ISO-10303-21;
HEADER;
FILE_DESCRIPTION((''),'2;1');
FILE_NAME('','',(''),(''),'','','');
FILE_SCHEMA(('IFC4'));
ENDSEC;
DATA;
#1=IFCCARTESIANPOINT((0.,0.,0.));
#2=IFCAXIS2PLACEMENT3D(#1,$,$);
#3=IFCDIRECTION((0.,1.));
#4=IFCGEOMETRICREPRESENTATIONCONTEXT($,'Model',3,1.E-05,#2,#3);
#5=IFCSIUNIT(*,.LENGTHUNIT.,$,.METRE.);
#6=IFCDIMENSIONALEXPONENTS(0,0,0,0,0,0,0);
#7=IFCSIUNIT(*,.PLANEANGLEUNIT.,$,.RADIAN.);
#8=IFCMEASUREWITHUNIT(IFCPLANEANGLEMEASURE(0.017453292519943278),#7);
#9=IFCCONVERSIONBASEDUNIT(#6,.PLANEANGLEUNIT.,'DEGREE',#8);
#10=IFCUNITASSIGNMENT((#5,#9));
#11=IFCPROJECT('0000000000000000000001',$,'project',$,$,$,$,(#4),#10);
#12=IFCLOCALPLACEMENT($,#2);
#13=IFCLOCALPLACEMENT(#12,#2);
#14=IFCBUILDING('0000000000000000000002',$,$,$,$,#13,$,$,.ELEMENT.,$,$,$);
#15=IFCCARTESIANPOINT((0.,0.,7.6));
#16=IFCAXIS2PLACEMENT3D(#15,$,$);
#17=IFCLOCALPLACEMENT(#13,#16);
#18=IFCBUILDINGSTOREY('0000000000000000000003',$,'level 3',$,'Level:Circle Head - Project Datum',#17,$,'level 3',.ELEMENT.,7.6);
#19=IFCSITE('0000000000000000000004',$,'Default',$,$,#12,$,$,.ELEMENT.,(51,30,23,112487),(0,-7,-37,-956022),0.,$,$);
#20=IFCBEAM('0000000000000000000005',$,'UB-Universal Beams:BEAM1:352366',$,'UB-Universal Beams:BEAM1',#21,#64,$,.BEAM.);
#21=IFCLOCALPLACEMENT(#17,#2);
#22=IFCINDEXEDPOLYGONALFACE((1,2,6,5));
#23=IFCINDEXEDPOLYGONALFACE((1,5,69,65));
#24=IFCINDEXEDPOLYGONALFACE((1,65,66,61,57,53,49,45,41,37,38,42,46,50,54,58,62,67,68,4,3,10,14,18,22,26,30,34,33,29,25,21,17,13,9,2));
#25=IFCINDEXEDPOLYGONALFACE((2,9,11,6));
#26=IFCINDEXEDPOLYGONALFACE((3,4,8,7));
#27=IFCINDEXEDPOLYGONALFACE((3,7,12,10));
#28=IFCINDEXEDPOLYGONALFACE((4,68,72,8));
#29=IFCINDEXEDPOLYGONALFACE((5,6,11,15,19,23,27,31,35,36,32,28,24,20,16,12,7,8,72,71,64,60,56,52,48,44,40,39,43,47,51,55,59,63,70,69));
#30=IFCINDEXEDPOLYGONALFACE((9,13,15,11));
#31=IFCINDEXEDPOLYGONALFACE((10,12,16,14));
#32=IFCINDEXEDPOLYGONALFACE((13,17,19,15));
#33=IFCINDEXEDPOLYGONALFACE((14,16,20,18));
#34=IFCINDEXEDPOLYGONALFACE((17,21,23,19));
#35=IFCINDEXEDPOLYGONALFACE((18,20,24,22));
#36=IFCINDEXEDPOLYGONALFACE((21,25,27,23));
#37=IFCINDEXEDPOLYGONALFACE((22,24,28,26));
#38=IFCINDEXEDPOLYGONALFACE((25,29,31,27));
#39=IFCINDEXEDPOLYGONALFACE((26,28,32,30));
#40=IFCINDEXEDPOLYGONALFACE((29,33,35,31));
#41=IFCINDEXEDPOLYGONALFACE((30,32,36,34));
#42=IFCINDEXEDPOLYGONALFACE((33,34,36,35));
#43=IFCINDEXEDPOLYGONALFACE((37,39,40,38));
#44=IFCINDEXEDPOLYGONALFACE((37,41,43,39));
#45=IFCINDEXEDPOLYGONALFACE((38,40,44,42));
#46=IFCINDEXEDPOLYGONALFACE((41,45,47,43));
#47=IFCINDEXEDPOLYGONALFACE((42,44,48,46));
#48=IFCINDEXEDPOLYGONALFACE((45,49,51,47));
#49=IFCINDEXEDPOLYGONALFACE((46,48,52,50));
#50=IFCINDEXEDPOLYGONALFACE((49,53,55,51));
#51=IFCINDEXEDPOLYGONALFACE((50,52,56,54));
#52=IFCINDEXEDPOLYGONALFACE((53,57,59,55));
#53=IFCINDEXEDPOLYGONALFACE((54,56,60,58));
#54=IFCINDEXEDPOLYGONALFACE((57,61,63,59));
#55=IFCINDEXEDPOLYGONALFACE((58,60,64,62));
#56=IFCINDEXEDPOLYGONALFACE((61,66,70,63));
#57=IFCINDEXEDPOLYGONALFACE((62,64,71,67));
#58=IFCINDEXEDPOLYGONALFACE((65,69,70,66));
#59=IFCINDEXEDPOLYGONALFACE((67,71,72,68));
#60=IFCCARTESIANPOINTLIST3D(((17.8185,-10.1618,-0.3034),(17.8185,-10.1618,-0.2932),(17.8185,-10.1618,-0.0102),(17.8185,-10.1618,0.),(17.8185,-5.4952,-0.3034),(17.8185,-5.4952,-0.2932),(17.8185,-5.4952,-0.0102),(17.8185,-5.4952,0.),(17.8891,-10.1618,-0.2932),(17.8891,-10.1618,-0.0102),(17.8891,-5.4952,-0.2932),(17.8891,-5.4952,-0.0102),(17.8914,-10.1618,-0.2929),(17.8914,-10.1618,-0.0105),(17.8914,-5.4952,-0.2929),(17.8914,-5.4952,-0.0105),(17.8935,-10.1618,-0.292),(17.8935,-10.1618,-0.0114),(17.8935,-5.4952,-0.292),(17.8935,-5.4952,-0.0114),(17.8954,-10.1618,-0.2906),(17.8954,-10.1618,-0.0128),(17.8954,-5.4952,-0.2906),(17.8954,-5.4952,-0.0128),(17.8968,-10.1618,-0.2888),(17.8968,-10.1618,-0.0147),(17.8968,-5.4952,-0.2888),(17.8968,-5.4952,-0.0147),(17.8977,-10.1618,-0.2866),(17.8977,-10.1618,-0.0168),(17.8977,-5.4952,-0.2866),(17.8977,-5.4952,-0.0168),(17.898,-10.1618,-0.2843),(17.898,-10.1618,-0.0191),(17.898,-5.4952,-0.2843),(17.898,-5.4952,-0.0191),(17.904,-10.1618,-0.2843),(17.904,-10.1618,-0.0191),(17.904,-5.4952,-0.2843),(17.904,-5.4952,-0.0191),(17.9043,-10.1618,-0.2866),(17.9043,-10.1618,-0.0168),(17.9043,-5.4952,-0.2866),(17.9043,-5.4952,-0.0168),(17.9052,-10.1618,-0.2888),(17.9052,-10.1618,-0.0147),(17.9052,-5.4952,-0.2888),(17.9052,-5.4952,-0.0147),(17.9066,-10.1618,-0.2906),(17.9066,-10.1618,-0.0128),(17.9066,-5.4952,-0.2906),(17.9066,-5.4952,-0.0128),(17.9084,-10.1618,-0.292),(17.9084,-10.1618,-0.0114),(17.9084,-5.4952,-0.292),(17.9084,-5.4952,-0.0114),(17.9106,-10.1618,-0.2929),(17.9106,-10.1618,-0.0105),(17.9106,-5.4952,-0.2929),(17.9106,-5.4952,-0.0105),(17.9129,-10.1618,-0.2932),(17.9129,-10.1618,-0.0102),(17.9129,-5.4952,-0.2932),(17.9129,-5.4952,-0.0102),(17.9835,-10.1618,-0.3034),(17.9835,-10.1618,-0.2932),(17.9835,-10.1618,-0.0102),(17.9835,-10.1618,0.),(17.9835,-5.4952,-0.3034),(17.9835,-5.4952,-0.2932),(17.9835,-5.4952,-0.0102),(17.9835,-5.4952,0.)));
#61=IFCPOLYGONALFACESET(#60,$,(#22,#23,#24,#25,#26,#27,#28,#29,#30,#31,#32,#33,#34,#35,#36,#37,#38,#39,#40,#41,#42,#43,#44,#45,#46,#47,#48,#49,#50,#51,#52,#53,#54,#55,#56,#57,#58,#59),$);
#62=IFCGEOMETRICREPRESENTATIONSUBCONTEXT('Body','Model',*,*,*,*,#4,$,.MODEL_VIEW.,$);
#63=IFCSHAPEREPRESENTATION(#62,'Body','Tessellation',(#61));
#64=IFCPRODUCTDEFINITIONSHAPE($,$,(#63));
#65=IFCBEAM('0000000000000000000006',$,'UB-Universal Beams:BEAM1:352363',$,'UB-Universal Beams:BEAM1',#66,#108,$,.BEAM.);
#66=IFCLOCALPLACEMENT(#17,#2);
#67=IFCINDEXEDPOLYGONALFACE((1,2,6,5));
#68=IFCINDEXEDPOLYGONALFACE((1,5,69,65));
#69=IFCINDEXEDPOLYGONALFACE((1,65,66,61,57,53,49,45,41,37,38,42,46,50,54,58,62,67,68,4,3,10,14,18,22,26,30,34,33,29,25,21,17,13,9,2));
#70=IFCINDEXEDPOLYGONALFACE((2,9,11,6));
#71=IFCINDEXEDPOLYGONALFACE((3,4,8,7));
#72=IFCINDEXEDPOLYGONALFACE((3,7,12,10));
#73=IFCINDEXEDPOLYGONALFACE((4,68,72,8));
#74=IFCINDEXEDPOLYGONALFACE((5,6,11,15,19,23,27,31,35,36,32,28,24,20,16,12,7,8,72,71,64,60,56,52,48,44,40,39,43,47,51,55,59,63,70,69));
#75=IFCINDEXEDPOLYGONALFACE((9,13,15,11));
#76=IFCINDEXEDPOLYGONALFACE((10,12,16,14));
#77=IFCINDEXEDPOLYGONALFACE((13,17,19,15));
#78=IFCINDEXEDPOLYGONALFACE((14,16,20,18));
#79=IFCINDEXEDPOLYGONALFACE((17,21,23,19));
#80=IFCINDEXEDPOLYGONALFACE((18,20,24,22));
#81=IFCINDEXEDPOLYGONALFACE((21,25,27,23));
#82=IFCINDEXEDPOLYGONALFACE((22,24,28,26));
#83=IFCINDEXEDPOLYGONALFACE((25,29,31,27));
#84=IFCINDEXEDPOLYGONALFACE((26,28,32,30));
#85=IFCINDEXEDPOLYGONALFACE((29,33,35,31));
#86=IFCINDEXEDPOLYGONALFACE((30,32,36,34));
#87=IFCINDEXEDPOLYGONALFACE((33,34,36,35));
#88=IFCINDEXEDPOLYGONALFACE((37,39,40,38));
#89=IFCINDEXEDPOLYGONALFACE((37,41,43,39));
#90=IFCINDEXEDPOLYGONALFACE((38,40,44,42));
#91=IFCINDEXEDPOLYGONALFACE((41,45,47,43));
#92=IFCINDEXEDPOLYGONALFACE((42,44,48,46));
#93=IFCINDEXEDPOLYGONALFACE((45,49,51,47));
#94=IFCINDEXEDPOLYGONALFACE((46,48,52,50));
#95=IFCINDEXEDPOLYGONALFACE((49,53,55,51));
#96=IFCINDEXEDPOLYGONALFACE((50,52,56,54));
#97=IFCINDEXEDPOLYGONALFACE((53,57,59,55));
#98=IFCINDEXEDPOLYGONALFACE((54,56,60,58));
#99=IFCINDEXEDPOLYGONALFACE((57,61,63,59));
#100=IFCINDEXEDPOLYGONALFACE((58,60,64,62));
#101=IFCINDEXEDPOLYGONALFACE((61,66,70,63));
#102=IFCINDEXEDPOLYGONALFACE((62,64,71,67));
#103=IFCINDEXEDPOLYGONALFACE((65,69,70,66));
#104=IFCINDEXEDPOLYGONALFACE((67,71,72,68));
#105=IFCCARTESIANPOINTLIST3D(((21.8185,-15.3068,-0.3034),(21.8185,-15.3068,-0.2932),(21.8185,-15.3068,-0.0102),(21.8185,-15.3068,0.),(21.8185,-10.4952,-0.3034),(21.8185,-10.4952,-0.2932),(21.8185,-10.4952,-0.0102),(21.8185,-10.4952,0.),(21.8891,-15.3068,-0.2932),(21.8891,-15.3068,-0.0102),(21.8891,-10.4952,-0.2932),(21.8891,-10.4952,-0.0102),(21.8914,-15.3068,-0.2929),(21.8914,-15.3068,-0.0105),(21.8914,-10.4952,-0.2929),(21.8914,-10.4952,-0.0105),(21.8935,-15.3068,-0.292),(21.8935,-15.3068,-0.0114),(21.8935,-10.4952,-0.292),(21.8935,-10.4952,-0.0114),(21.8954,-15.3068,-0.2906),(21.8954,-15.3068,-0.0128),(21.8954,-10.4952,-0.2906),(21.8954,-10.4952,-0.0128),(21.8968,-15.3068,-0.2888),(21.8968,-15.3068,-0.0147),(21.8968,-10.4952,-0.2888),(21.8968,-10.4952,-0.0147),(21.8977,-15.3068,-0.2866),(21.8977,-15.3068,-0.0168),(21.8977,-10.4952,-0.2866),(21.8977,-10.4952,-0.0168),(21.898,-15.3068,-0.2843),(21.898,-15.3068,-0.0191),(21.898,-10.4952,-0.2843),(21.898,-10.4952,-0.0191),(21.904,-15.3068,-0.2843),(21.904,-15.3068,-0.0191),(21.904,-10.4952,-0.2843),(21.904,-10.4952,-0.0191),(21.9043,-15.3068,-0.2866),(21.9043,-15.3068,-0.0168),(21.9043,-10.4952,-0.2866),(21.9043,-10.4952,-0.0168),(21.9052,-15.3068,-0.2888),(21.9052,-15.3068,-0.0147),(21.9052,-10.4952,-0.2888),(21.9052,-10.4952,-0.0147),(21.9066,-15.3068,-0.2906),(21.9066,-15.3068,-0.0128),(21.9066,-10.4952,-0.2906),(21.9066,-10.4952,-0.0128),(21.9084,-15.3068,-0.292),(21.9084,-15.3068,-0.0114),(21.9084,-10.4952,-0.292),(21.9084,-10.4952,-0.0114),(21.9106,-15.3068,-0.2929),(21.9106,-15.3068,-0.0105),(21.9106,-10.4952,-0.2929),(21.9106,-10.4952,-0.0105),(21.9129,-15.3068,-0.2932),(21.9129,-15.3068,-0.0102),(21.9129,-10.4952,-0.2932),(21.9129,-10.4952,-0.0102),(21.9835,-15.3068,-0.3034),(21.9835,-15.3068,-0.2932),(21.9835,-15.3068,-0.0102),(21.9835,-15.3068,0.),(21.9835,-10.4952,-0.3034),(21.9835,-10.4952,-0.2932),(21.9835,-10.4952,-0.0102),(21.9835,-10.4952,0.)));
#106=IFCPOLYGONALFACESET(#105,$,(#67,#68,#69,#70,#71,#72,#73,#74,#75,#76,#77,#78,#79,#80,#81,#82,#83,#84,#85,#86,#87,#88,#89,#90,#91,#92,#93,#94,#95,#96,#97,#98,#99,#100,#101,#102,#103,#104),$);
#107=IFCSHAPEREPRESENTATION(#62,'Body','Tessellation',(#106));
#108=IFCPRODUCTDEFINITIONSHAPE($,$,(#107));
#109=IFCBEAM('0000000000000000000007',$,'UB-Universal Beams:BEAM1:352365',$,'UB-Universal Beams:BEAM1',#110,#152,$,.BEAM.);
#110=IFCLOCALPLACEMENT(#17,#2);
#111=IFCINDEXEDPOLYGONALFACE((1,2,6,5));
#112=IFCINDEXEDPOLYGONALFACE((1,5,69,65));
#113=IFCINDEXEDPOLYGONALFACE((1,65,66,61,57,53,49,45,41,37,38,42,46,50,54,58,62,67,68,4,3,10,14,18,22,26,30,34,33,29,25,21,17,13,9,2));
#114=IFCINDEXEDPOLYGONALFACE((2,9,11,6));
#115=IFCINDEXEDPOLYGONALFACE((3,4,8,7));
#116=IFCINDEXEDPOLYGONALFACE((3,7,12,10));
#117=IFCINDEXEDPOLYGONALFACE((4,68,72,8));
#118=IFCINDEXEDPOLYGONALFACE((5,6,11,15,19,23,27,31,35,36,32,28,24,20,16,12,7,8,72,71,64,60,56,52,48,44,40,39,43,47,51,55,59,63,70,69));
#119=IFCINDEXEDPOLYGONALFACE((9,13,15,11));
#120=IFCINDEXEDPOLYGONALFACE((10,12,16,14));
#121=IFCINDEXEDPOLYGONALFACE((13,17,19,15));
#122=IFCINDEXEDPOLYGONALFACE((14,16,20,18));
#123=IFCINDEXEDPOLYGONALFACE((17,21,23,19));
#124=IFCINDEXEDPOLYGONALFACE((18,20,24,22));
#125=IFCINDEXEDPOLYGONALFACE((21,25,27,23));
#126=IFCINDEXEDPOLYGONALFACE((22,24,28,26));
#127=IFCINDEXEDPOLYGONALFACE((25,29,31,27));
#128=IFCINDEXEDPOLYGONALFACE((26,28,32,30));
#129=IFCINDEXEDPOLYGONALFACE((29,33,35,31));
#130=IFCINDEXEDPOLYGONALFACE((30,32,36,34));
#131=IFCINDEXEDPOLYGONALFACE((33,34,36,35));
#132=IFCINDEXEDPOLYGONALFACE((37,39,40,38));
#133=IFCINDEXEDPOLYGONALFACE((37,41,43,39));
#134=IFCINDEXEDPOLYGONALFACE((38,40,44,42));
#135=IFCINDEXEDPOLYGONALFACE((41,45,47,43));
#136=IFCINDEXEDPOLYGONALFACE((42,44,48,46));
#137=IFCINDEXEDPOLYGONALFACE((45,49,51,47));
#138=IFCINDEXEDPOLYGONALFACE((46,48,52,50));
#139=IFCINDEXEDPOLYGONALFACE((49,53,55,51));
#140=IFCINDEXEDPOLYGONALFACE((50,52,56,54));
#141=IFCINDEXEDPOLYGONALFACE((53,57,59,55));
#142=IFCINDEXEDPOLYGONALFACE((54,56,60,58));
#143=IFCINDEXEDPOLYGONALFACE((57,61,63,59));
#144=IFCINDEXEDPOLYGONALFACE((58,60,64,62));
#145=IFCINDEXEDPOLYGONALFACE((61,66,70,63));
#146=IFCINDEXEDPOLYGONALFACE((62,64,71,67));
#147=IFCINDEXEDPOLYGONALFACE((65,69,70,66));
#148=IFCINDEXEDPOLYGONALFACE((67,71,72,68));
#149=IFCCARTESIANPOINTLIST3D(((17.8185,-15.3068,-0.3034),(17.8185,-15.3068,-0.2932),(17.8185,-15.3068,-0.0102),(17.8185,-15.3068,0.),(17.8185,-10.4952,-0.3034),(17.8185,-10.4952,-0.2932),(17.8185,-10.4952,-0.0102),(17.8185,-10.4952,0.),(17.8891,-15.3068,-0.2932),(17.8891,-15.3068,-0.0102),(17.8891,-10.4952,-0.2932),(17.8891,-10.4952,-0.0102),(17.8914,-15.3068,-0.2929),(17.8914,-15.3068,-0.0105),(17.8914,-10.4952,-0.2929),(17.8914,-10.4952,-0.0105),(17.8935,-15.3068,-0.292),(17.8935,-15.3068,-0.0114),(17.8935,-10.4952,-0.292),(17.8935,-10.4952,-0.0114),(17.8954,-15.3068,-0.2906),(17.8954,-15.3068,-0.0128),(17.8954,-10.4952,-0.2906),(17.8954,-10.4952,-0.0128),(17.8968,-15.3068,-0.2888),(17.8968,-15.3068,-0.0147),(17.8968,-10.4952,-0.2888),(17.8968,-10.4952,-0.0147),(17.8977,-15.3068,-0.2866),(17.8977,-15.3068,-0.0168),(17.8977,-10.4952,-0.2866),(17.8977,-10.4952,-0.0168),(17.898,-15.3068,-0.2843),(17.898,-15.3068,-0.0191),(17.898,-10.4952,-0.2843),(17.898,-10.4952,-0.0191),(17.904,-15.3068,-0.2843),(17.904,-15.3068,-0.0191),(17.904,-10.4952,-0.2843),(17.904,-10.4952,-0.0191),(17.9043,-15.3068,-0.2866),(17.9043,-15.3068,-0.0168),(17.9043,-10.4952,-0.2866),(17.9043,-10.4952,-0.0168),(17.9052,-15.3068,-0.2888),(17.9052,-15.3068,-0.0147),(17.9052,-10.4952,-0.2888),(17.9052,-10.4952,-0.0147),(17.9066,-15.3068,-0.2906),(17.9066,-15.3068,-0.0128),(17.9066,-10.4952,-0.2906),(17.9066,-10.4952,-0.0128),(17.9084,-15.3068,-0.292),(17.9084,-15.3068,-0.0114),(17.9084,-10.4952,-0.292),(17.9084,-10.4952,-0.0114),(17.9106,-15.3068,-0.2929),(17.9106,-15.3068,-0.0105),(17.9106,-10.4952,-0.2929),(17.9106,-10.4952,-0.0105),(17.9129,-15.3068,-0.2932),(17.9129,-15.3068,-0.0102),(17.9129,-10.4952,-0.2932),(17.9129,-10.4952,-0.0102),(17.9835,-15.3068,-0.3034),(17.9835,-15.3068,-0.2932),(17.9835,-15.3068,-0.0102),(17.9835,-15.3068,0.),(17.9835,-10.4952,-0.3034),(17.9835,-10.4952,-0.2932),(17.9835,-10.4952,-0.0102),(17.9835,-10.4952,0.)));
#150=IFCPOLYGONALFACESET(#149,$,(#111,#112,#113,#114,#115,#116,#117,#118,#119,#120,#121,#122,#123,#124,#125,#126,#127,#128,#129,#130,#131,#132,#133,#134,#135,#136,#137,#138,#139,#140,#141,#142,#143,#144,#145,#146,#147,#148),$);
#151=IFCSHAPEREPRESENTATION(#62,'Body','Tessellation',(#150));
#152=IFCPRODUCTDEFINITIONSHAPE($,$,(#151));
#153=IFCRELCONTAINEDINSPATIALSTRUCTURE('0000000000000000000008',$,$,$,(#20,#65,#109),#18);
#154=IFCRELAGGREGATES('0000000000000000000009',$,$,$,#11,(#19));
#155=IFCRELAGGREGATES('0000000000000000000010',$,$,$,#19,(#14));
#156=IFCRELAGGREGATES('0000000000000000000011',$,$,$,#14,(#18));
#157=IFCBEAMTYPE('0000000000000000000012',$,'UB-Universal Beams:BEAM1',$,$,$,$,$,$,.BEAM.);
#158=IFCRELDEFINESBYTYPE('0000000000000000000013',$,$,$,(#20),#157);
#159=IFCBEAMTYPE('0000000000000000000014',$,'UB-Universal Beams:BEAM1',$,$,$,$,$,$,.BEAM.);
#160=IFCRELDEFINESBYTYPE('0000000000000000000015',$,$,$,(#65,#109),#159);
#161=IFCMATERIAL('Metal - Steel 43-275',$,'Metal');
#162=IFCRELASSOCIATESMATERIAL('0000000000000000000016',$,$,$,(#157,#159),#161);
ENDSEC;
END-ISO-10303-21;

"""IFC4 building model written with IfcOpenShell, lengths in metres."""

from ifc_helpers import new_model, entity, si_unit, converted_unit, direction, frame, frame_2d, origin, place, context, subcontext, project, spatial, polyline, circle_curve, parameter, trimmed, segment, composite_curve, outline, extrude, source, transform, mapped, material, material_profile, profile_set, type_object, type_shapes, element, save


model = new_model("IFC4")

# Units and contexts
model_context = context("Model", 3, precision=1e-05, world=origin(), true_north=direction((0.0, 1.0)))
body_context = subcontext(model_context, "Body", "Model", "MODEL_VIEW")
ifc_project = project(units=[si_unit("LENGTHUNIT", "METRE"), converted_unit("PLANEANGLEUNIT", "DEGREE", entity("IfcPlaneAngleMeasure", 0.017453292519943278), si_unit("PLANEANGLEUNIT", "RADIAN"), dimensions=[0, 0, 0, 0, 0, 0, 0])], contexts=[model_context])

# Site, building, storey
site_placement = place(None, origin())
site = spatial("IfcSite", under=ifc_project, at=site_placement, Name="Default", CompositionType="ELEMENT", RefLatitude=(51, 30, 23, 112487), RefLongitude=(0, -7, -37, -956022), RefElevation=0.0)
building_placement = place(site_placement, origin())
building = spatial("IfcBuilding", under=site, at=building_placement, CompositionType="ELEMENT")
storey_placement = place(building_placement, frame((0.0, 0.0, 7.6)))
storey = spatial("IfcBuildingStorey", under=building, at=storey_placement, Name="level 3", ObjectType="Level:Circle Head - Project Datum", LongName="level 3", CompositionType="ELEMENT", Elevation=7.6)

# Shared definitions
ifc_material_1 = material(Name="Metal - Steel 43-275", Category="Metal")

# Beams
ifc_material_profile_1 = material_profile(ifc_material_1, outline(composite_curve([segment(polyline([(-0.0825, -0.1415), (-0.0825, -0.1517)]), True, "CONTINUOUS"), segment(polyline([(-0.0825, -0.1517), (0.0825, -0.1517)]), True, "CONTINUOUS"), segment(polyline([(0.0825, -0.1517), (0.0825, -0.1415)]), True, "CONTINUOUS"), segment(polyline([(0.0825, -0.1415), (0.0119, -0.1415)]), True, "CONTINUOUS"), segment(trimmed(circle_curve(frame_2d((0.0119, -0.1326), x_axis=(1.0, 0.0)), 0.0089), [parameter(180.0)], [parameter(270.0)], True, "PARAMETER"), False, "CONTINUOUS"), segment(polyline([(0.003, -0.1326), (0.003, 0.1326)]), True, "CONTINUOUS"), segment(trimmed(circle_curve(frame_2d((0.0119, 0.1326), x_axis=(1.0, 0.0)), 0.0089), [parameter(90.0)], [parameter(180.0)], True, "PARAMETER"), False, "CONTINUOUS"), segment(polyline([(0.0119, 0.1415), (0.0825, 0.1415)]), True, "CONTINUOUS"), segment(polyline([(0.0825, 0.1415), (0.0825, 0.1517)]), True, "CONTINUOUS"), segment(polyline([(0.0825, 0.1517), (-0.0825, 0.1517)]), True, "CONTINUOUS"), segment(polyline([(-0.0825, 0.1517), (-0.0825, 0.1415)]), True, "CONTINUOUS"), segment(polyline([(-0.0825, 0.1415), (-0.0119, 0.1415)]), True, "CONTINUOUS"), segment(trimmed(circle_curve(frame_2d((-0.0119, 0.1326), x_axis=(1.0, 0.0)), 0.0089), [parameter(360.0)], [parameter(90.0)], True, "PARAMETER"), False, "CONTINUOUS"), segment(polyline([(-0.003, 0.1326), (-0.003, -0.1326)]), True, "CONTINUOUS"), segment(trimmed(circle_curve(frame_2d((-0.0119, -0.1326), x_axis=(1.0, 0.0)), 0.0089), [parameter(270.0)], [parameter(360.0)], True, "PARAMETER"), False, "CONTINUOUS"), segment(polyline([(-0.0119, -0.1415), (-0.0825, -0.1415)]), True, "CONTINUOUS")], self_intersect=False)), Name="BEAM1")
ifc_profile_set_1 = profile_set([ifc_material_profile_1], Name="BEAM1")
beam_type_1 = type_object("IfcBeamType", Name="UB-Universal Beams:BEAM1", PredefinedType="BEAM", material=ifc_profile_set_1)
shared_shape_1 = source(origin(), body_context, "Body", "SweptSolid", [
    extrude(outline(composite_curve([segment(polyline([(-0.0825, -0.1415), (-0.0825, -0.1517)]), True, "CONTINUOUS"), segment(polyline([(-0.0825, -0.1517), (0.0825, -0.1517)]), True, "CONTINUOUS"), segment(polyline([(0.0825, -0.1517), (0.0825, -0.1415)]), True, "CONTINUOUS"), segment(polyline([(0.0825, -0.1415), (0.0119, -0.1415)]), True, "CONTINUOUS"), segment(trimmed(circle_curve(frame_2d((0.0119, -0.1326), x_axis=(0.0, -1.0)), 0.0089), [parameter(270.0)], [parameter(360.0)], True, "PARAMETER"), False, "CONTINUOUS"), segment(polyline([(0.003, -0.1326), (0.003, 0.1326)]), True, "CONTINUOUS"), segment(trimmed(circle_curve(frame_2d((0.0119, 0.1326), x_axis=(-1.0, 0.0)), 0.0089), [parameter(270.0)], [parameter(360.0)], True, "PARAMETER"), False, "CONTINUOUS"), segment(polyline([(0.0119, 0.1415), (0.0825, 0.1415)]), True, "CONTINUOUS"), segment(polyline([(0.0825, 0.1415), (0.0825, 0.1517)]), True, "CONTINUOUS"), segment(polyline([(0.0825, 0.1517), (-0.0825, 0.1517)]), True, "CONTINUOUS"), segment(polyline([(-0.0825, 0.1517), (-0.0825, 0.1415)]), True, "CONTINUOUS"), segment(polyline([(-0.0825, 0.1415), (-0.0119, 0.1415)]), True, "CONTINUOUS"), segment(trimmed(circle_curve(frame_2d((-0.0119, 0.1326), x_axis=(0.0, 1.0)), 0.0089), [parameter(270.0)], [parameter(360.0)], True, "PARAMETER"), False, "CONTINUOUS"), segment(polyline([(-0.003, 0.1326), (-0.003, -0.1326)]), True, "CONTINUOUS"), segment(trimmed(circle_curve(frame_2d((-0.0119, -0.1326), x_axis=(1.0, 0.0)), 0.0089), [parameter(270.0)], [parameter(0.0)], True, "PARAMETER"), False, "CONTINUOUS"), segment(polyline([(-0.0119, -0.1415), (-0.0825, -0.1415)]), True, "CONTINUOUS")], self_intersect=False)), frame((-2.3333, 0.0, 0.0), z_axis=(-1.0, 0.0, 0.0), x_axis=(0.0, -1.0, 0.0)), (0.0, 0.0, -1.0), 4.6666),
])
type_shapes(beam_type_1, [shared_shape_1])
for number, where, z_axis, x_axis, name in (
    (1, (17.901, -7.8285, -0.1517), (0.0, 0.0, 1.0), (0.0, -1.0, 0.0), "UB-Universal Beams:BEAM1:352366"),
):
    element("IfcBeam", number, at=place(storey_placement, frame(where, z_axis=z_axis, x_axis=x_axis)), inside=storey, type_object=beam_type_1, Name=name, ObjectType="UB-Universal Beams:BEAM1", PredefinedType="BEAM", context=body_context, shape_type="MappedRepresentation", body=[
        mapped(shared_shape_1, transform((0.0, 0.0, 0.0), scale=1.0)),
    ])
beam_type_2 = type_object("IfcBeamType", Name="UB-Universal Beams:BEAM1", PredefinedType="BEAM", material=ifc_profile_set_1)
shared_shape_2 = source(origin(), body_context, "Body", "SweptSolid", [
    extrude(outline(composite_curve([segment(polyline([(-0.0825, -0.1415), (-0.0825, -0.1517)]), True, "CONTINUOUS"), segment(polyline([(-0.0825, -0.1517), (0.0825, -0.1517)]), True, "CONTINUOUS"), segment(polyline([(0.0825, -0.1517), (0.0825, -0.1415)]), True, "CONTINUOUS"), segment(polyline([(0.0825, -0.1415), (0.0119, -0.1415)]), True, "CONTINUOUS"), segment(trimmed(circle_curve(frame_2d((0.0119, -0.1326), x_axis=(0.0, -1.0)), 0.0089), [parameter(270.0)], [parameter(360.0)], True, "PARAMETER"), False, "CONTINUOUS"), segment(polyline([(0.003, -0.1326), (0.003, 0.1326)]), True, "CONTINUOUS"), segment(trimmed(circle_curve(frame_2d((0.0119, 0.1326), x_axis=(-1.0, 0.0)), 0.0089), [parameter(270.0)], [parameter(360.0)], True, "PARAMETER"), False, "CONTINUOUS"), segment(polyline([(0.0119, 0.1415), (0.0825, 0.1415)]), True, "CONTINUOUS"), segment(polyline([(0.0825, 0.1415), (0.0825, 0.1517)]), True, "CONTINUOUS"), segment(polyline([(0.0825, 0.1517), (-0.0825, 0.1517)]), True, "CONTINUOUS"), segment(polyline([(-0.0825, 0.1517), (-0.0825, 0.1415)]), True, "CONTINUOUS"), segment(polyline([(-0.0825, 0.1415), (-0.0119, 0.1415)]), True, "CONTINUOUS"), segment(trimmed(circle_curve(frame_2d((-0.0119, 0.1326), x_axis=(0.0, 1.0)), 0.0089), [parameter(270.0)], [parameter(360.0)], True, "PARAMETER"), False, "CONTINUOUS"), segment(polyline([(-0.003, 0.1326), (-0.003, -0.1326)]), True, "CONTINUOUS"), segment(trimmed(circle_curve(frame_2d((-0.0119, -0.1326), x_axis=(1.0, 0.0)), 0.0089), [parameter(270.0)], [parameter(0.0)], True, "PARAMETER"), False, "CONTINUOUS"), segment(polyline([(-0.0119, -0.1415), (-0.0825, -0.1415)]), True, "CONTINUOUS")], self_intersect=False)), frame((-2.4058, 0.0, 0.0), z_axis=(-1.0, 0.0, 0.0), x_axis=(0.0, -1.0, 0.0)), (0.0, 0.0, -1.0), 4.8116),
])
type_shapes(beam_type_2, [shared_shape_2])
for number, where, z_axis, x_axis, name in (
    (2, (21.901, -12.901, -0.1517), (0.0, 0.0, 1.0), (0.0, 1.0, 0.0), "UB-Universal Beams:BEAM1:352363"),
    (3, (17.901, -12.901, -0.1517), (0.0, 0.0, 1.0), (0.0, -1.0, 0.0), "UB-Universal Beams:BEAM1:352365"),
):
    element("IfcBeam", number, at=place(storey_placement, frame(where, z_axis=z_axis, x_axis=x_axis)), inside=storey, type_object=beam_type_2, Name=name, ObjectType="UB-Universal Beams:BEAM1", PredefinedType="BEAM", context=body_context, shape_type="MappedRepresentation", body=[
        mapped(shared_shape_2, transform((0.0, 0.0, 0.0), scale=1.0)),
    ])

save(model, "model.ifc")
